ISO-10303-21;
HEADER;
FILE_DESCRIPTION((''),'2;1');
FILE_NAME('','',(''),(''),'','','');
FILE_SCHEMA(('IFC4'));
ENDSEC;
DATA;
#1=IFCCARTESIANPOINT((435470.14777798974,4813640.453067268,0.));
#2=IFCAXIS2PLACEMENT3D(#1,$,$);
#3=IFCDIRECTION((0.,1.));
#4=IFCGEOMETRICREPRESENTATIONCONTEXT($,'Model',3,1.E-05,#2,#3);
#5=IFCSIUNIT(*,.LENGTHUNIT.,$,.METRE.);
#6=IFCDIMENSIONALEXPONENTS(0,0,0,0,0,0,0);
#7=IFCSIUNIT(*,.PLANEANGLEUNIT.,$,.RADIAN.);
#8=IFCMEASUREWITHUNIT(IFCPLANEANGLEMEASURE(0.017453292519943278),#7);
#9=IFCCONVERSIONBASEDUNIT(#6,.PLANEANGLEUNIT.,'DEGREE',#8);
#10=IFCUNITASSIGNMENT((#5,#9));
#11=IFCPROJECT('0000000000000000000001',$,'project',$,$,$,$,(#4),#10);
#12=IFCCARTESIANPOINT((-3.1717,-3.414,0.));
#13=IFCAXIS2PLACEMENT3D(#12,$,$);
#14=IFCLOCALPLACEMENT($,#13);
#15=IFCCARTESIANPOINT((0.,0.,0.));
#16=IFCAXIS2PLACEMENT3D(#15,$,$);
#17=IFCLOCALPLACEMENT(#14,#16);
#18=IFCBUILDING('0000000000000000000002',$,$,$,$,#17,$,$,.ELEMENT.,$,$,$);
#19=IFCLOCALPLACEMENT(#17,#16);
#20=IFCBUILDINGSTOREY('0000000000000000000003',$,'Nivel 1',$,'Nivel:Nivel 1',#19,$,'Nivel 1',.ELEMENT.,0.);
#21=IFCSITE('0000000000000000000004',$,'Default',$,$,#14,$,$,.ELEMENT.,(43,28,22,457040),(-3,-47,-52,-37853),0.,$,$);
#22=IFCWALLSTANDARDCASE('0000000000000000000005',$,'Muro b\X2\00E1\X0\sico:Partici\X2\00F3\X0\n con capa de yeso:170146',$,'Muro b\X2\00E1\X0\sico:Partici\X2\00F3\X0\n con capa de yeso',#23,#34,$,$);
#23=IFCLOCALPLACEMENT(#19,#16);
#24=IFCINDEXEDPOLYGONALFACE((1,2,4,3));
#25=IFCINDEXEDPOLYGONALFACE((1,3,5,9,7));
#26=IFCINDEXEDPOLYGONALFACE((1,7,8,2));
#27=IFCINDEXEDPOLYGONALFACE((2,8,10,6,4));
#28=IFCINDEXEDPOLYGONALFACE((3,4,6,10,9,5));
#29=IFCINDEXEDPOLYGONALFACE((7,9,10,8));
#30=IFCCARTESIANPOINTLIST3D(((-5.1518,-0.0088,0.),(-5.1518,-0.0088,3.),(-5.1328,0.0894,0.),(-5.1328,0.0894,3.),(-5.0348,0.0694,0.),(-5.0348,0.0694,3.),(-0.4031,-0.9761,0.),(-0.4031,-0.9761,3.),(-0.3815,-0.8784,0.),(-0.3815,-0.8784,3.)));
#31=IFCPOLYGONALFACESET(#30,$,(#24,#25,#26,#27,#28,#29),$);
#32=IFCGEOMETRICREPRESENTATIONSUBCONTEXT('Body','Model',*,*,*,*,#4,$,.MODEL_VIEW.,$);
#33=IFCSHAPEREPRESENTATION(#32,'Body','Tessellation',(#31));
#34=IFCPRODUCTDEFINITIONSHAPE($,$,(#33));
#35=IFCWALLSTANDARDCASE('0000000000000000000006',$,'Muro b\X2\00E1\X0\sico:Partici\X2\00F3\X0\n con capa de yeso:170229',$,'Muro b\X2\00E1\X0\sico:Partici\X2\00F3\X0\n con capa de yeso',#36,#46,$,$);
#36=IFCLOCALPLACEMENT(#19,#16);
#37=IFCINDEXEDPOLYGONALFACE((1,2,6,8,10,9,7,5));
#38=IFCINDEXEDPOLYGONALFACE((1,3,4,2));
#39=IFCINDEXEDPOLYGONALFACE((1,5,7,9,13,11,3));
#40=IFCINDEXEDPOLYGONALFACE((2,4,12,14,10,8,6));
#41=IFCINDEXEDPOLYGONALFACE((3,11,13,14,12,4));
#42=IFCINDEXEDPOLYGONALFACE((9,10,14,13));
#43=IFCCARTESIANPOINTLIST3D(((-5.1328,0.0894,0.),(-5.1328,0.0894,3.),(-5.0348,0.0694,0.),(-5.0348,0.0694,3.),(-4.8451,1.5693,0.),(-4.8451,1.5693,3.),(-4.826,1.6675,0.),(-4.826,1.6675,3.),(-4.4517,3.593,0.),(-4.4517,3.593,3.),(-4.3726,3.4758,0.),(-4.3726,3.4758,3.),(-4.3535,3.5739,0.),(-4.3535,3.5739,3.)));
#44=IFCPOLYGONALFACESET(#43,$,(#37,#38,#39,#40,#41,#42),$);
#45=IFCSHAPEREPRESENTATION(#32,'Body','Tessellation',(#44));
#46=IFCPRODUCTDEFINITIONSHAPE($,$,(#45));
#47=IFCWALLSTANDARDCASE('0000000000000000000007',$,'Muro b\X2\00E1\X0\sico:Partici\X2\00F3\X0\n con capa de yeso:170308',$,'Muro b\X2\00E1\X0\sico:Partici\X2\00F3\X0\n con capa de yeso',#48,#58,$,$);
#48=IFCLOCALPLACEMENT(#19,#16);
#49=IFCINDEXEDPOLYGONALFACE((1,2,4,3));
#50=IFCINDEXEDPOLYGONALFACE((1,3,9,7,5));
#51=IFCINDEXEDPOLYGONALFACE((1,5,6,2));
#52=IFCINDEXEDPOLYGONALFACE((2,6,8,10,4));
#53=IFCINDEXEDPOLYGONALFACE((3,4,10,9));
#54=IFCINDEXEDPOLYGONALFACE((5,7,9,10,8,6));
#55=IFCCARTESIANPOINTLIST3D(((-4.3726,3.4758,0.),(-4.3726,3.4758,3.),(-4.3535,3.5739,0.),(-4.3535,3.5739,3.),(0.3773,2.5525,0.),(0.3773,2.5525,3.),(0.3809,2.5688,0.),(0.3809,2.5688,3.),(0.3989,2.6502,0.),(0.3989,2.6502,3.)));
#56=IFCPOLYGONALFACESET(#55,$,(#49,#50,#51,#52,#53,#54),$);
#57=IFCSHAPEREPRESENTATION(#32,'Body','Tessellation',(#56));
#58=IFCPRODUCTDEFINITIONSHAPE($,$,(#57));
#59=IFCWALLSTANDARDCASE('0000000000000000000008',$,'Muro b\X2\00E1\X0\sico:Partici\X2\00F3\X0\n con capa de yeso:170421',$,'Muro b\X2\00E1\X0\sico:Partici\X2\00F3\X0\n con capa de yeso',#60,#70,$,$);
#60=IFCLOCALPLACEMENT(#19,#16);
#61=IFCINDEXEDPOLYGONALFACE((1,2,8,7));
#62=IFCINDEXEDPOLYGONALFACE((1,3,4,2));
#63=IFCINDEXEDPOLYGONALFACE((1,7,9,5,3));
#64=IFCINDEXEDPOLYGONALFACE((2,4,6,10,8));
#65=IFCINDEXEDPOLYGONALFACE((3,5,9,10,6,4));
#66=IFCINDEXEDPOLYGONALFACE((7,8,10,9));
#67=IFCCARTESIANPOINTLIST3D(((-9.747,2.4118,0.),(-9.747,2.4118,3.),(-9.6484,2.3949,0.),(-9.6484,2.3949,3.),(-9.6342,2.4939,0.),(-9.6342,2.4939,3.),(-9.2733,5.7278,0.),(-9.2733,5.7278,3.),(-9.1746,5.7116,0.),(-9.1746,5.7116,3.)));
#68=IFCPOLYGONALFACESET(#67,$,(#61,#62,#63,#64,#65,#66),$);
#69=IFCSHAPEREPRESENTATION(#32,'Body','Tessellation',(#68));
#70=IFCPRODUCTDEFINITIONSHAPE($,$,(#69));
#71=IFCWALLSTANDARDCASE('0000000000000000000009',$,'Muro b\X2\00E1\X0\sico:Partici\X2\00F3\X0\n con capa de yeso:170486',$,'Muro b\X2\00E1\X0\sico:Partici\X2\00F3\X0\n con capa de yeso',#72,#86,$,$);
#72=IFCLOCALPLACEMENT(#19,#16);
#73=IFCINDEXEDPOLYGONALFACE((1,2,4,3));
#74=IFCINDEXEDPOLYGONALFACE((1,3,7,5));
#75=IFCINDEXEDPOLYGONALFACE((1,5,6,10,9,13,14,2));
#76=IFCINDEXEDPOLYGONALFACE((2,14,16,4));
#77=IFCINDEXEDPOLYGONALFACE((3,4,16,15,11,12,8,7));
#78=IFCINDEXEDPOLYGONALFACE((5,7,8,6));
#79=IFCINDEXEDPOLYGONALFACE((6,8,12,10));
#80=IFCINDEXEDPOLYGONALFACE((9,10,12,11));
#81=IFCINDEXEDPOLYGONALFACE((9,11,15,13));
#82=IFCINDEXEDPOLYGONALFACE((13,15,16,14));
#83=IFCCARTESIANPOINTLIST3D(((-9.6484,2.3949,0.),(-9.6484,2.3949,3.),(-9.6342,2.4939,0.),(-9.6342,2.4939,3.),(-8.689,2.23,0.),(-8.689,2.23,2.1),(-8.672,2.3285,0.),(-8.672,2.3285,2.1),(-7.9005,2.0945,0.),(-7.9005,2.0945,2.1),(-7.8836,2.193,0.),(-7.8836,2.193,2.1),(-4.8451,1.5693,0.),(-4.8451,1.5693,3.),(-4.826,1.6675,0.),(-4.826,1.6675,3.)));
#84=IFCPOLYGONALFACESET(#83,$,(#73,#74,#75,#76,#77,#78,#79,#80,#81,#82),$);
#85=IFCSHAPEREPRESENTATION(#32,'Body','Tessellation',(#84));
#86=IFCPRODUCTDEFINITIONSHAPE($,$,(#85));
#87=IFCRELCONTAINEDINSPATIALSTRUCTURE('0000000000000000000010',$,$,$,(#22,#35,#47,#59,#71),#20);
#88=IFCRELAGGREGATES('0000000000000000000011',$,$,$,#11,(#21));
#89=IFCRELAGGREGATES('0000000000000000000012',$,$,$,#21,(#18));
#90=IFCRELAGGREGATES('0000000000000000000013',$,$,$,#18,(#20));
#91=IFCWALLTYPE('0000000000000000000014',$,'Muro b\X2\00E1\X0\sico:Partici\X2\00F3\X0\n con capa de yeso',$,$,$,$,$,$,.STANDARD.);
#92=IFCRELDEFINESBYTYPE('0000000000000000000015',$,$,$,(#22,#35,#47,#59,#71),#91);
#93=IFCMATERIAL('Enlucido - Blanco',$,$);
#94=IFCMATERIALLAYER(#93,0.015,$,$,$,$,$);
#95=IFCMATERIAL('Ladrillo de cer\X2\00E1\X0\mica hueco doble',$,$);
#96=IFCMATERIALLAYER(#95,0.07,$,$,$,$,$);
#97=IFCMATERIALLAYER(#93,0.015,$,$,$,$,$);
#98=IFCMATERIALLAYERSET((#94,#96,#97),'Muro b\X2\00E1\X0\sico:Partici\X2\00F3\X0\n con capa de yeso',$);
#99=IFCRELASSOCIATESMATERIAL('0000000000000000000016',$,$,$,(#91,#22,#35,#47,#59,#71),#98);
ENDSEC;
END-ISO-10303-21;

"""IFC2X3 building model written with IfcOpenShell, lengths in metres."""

from ifc_helpers import new_model, entity, si_unit, converted_unit, direction, frame, frame_2d, origin, place, context, subcontext, project, spatial, polyline, rectangle, outline, extrude, material, layer, layer_set, layer_usage, type_object, element, save


model = new_model("IFC2X3")

# Units and contexts
model_context = context("Model", 3, precision=1e-05, world=frame((435470.14777798974, 4813640.453067268, 0.0)), true_north=direction((0.0, 1.0)))
body_context = subcontext(model_context, "Body", "Model", "MODEL_VIEW")
ifc_project = project(units=[si_unit("LENGTHUNIT", "METRE"), converted_unit("PLANEANGLEUNIT", "DEGREE", entity("IfcPlaneAngleMeasure", 0.017453292519943278), si_unit("PLANEANGLEUNIT", "RADIAN"), dimensions=[0, 0, 0, 0, 0, 0, 0])], contexts=[model_context])

# Site, building, storey
site_placement = place(None, frame((-3.1717, -3.414, 0.0)))
site = spatial("IfcSite", under=ifc_project, at=site_placement, Name="Default", CompositionType="ELEMENT", RefLatitude=(43, 28, 22, 457040), RefLongitude=(-3, -47, -52, -37853), RefElevation=0.0)
building_placement = place(site_placement, origin())
building = spatial("IfcBuilding", under=site, at=building_placement, CompositionType="ELEMENT")
storey_placement = place(building_placement, origin())
storey = spatial("IfcBuildingStorey", under=building, at=storey_placement, Name="Nivel 1", ObjectType="Nivel:Nivel 1", LongName="Nivel 1", CompositionType="ELEMENT", Elevation=0.0)

# Shared definitions
ifc_material_1 = material(Name="Enlucido - Blanco")
ifc_layer_1 = layer(ifc_material_1, 0.015)
ifc_material_2 = material(Name="Ladrillo de cerámica hueco doble")
ifc_layer_2 = layer(ifc_material_2, 0.07)
ifc_layer_3 = layer(ifc_material_1, 0.015)
ifc_layer_set_1 = layer_set([ifc_layer_1, ifc_layer_2, ifc_layer_3], Name="Muro básico:Partición con capa de yeso")
wall_type_1 = type_object("IfcWallType", Name="Muro básico:Partición con capa de yeso", PredefinedType="STANDARD", material=ifc_layer_set_1)

# Walls
ifc_layer_usage_1 = layer_usage(ifc_layer_set_1, "AXIS2", "POSITIVE", -0.05)
wall_1_placement = place(storey_placement, frame((-0.3915, -0.9274, 0.0), z_axis=(0.0, 0.0, 1.0), x_axis=(-0.979879, 0.199592, 0.0)))
element("IfcWallStandardCase", 1, at=wall_1_placement, inside=storey, type_object=wall_type_1, material=ifc_layer_usage_1, Name="Muro básico:Partición con capa de yeso:170146", ObjectType="Muro básico:Partición con capa de yeso", context=body_context, shape_type="SweptSolid", body=[
    extrude(outline(polyline([(4.8488, -0.05), (4.8479, 0.05), (0.0017, 0.05), (0.0, -0.05), (4.7488, -0.05), (4.8488, -0.05)])), origin(), (0.0, 0.0, 1.0), 3.0),
])
ifc_layer_usage_2 = layer_usage(ifc_layer_set_1, "AXIS2", "POSITIVE", -0.05)
wall_2_placement = place(storey_placement, frame((-5.0838, 0.0789, 0.0), z_axis=(0.0, 0.0, 1.0), x_axis=(0.190809, 0.981627, 0.0)))
element("IfcWallStandardCase", 2, at=wall_2_placement, inside=storey, type_object=wall_type_1, material=ifc_layer_usage_2, Name="Muro básico:Partición con capa de yeso:170229", ObjectType="Muro básico:Partición con capa de yeso", context=body_context, shape_type="SweptSolid", body=[
    extrude(outline(polyline([(3.5701, -0.05), (3.5701, 0.05), (1.6086, 0.05), (1.5086, 0.05), (0.0009, 0.05), (0.0, -0.05), (3.4701, -0.05), (3.5701, -0.05)])), origin(), (0.0, 0.0, 1.0), 3.0),
])
ifc_layer_usage_3 = layer_usage(ifc_layer_set_1, "AXIS2", "POSITIVE", -0.05)
wall_3_placement = place(storey_placement, frame((-4.3631, 3.5249, 0.0), z_axis=(0.0, 0.0, 1.0), x_axis=(0.981627, -0.190809, 0.0)))
element("IfcWallStandardCase", 3, at=wall_3_placement, inside=storey, type_object=wall_type_1, material=ifc_layer_usage_3, Name="Muro básico:Partición con capa de yeso:170308", ObjectType="Muro básico:Partición con capa de yeso", context=body_context, shape_type="SweptSolid", body=[
    extrude(outline(polyline([(4.8388, -0.05), (4.8392, -0.0333), (4.8414, 0.05), (0.0, 0.05), (0.0, -0.05), (4.8388, -0.05)])), origin(), (0.0, 0.0, 1.0), 3.0),
])
ifc_layer_usage_4 = layer_usage(ifc_layer_set_1, "AXIS2", "NEGATIVE", 0.05)
wall_4_placement = place(storey_placement, frame((-9.2238, 5.7207, 0.0), z_axis=(0.0, 0.0, 1.0), x_axis=(-0.141418, -0.98995, 0.0)))
element("IfcWallStandardCase", 4, at=wall_4_placement, inside=storey, type_object=wall_type_1, material=ifc_layer_usage_4, Name="Muro básico:Partición con capa de yeso:170421", ObjectType="Muro básico:Partición con capa de yeso", context=body_context, shape_type="SweptSolid", body=[
    extrude(outline(polyline([(3.3496, -0.05), (3.3524, 0.05), (3.2524, 0.05), (0.002, 0.05), (0.0, -0.05), (3.3496, -0.05)])), origin(), (0.0, 0.0, 1.0), 3.0),
])

# Wall, opening
ifc_layer_usage_5 = layer_usage(ifc_layer_set_1, "AXIS2", "NEGATIVE", 0.05)
wall_5_placement = place(storey_placement, frame((-9.6427, 2.4446, 0.0), z_axis=(0.0, 0.0, 1.0), x_axis=(0.98555, -0.169385, 0.0)))
wall_5 = element("IfcWallStandardCase", 5, at=wall_5_placement, inside=storey, type_object=wall_type_1, material=ifc_layer_usage_5, Name="Muro básico:Partición con capa de yeso:170486", ObjectType="Muro básico:Partición con capa de yeso", context=body_context, shape_type="SweptSolid", body=[
    extrude(outline(polyline([(0.0028, -0.05), (4.8766, -0.05), (4.8787, 0.05), (0.0, 0.05), (0.0028, -0.05)])), origin(), (0.0, 0.0, 1.0), 3.0),
])
opening_1_placement = place(wall_5_placement, frame((1.7763, 0.05, 0.0)))
element("IfcOpeningElement", 6, at=opening_1_placement, cuts=wall_5, ObjectType="Opening", context=body_context, shape_type="SweptSolid", body=[
    extrude(rectangle(XDim=2.1, YDim=0.8, at=frame_2d((1.05, 0.4), x_axis=(1.0, 0.0))), frame((0.0, 0.0, 0.0), z_axis=(0.0, -1.0, 0.0), x_axis=(0.0, 0.0, 1.0)), (0.0, 0.0, 1.0), 0.1),
])

save(model, "model.ifc")
